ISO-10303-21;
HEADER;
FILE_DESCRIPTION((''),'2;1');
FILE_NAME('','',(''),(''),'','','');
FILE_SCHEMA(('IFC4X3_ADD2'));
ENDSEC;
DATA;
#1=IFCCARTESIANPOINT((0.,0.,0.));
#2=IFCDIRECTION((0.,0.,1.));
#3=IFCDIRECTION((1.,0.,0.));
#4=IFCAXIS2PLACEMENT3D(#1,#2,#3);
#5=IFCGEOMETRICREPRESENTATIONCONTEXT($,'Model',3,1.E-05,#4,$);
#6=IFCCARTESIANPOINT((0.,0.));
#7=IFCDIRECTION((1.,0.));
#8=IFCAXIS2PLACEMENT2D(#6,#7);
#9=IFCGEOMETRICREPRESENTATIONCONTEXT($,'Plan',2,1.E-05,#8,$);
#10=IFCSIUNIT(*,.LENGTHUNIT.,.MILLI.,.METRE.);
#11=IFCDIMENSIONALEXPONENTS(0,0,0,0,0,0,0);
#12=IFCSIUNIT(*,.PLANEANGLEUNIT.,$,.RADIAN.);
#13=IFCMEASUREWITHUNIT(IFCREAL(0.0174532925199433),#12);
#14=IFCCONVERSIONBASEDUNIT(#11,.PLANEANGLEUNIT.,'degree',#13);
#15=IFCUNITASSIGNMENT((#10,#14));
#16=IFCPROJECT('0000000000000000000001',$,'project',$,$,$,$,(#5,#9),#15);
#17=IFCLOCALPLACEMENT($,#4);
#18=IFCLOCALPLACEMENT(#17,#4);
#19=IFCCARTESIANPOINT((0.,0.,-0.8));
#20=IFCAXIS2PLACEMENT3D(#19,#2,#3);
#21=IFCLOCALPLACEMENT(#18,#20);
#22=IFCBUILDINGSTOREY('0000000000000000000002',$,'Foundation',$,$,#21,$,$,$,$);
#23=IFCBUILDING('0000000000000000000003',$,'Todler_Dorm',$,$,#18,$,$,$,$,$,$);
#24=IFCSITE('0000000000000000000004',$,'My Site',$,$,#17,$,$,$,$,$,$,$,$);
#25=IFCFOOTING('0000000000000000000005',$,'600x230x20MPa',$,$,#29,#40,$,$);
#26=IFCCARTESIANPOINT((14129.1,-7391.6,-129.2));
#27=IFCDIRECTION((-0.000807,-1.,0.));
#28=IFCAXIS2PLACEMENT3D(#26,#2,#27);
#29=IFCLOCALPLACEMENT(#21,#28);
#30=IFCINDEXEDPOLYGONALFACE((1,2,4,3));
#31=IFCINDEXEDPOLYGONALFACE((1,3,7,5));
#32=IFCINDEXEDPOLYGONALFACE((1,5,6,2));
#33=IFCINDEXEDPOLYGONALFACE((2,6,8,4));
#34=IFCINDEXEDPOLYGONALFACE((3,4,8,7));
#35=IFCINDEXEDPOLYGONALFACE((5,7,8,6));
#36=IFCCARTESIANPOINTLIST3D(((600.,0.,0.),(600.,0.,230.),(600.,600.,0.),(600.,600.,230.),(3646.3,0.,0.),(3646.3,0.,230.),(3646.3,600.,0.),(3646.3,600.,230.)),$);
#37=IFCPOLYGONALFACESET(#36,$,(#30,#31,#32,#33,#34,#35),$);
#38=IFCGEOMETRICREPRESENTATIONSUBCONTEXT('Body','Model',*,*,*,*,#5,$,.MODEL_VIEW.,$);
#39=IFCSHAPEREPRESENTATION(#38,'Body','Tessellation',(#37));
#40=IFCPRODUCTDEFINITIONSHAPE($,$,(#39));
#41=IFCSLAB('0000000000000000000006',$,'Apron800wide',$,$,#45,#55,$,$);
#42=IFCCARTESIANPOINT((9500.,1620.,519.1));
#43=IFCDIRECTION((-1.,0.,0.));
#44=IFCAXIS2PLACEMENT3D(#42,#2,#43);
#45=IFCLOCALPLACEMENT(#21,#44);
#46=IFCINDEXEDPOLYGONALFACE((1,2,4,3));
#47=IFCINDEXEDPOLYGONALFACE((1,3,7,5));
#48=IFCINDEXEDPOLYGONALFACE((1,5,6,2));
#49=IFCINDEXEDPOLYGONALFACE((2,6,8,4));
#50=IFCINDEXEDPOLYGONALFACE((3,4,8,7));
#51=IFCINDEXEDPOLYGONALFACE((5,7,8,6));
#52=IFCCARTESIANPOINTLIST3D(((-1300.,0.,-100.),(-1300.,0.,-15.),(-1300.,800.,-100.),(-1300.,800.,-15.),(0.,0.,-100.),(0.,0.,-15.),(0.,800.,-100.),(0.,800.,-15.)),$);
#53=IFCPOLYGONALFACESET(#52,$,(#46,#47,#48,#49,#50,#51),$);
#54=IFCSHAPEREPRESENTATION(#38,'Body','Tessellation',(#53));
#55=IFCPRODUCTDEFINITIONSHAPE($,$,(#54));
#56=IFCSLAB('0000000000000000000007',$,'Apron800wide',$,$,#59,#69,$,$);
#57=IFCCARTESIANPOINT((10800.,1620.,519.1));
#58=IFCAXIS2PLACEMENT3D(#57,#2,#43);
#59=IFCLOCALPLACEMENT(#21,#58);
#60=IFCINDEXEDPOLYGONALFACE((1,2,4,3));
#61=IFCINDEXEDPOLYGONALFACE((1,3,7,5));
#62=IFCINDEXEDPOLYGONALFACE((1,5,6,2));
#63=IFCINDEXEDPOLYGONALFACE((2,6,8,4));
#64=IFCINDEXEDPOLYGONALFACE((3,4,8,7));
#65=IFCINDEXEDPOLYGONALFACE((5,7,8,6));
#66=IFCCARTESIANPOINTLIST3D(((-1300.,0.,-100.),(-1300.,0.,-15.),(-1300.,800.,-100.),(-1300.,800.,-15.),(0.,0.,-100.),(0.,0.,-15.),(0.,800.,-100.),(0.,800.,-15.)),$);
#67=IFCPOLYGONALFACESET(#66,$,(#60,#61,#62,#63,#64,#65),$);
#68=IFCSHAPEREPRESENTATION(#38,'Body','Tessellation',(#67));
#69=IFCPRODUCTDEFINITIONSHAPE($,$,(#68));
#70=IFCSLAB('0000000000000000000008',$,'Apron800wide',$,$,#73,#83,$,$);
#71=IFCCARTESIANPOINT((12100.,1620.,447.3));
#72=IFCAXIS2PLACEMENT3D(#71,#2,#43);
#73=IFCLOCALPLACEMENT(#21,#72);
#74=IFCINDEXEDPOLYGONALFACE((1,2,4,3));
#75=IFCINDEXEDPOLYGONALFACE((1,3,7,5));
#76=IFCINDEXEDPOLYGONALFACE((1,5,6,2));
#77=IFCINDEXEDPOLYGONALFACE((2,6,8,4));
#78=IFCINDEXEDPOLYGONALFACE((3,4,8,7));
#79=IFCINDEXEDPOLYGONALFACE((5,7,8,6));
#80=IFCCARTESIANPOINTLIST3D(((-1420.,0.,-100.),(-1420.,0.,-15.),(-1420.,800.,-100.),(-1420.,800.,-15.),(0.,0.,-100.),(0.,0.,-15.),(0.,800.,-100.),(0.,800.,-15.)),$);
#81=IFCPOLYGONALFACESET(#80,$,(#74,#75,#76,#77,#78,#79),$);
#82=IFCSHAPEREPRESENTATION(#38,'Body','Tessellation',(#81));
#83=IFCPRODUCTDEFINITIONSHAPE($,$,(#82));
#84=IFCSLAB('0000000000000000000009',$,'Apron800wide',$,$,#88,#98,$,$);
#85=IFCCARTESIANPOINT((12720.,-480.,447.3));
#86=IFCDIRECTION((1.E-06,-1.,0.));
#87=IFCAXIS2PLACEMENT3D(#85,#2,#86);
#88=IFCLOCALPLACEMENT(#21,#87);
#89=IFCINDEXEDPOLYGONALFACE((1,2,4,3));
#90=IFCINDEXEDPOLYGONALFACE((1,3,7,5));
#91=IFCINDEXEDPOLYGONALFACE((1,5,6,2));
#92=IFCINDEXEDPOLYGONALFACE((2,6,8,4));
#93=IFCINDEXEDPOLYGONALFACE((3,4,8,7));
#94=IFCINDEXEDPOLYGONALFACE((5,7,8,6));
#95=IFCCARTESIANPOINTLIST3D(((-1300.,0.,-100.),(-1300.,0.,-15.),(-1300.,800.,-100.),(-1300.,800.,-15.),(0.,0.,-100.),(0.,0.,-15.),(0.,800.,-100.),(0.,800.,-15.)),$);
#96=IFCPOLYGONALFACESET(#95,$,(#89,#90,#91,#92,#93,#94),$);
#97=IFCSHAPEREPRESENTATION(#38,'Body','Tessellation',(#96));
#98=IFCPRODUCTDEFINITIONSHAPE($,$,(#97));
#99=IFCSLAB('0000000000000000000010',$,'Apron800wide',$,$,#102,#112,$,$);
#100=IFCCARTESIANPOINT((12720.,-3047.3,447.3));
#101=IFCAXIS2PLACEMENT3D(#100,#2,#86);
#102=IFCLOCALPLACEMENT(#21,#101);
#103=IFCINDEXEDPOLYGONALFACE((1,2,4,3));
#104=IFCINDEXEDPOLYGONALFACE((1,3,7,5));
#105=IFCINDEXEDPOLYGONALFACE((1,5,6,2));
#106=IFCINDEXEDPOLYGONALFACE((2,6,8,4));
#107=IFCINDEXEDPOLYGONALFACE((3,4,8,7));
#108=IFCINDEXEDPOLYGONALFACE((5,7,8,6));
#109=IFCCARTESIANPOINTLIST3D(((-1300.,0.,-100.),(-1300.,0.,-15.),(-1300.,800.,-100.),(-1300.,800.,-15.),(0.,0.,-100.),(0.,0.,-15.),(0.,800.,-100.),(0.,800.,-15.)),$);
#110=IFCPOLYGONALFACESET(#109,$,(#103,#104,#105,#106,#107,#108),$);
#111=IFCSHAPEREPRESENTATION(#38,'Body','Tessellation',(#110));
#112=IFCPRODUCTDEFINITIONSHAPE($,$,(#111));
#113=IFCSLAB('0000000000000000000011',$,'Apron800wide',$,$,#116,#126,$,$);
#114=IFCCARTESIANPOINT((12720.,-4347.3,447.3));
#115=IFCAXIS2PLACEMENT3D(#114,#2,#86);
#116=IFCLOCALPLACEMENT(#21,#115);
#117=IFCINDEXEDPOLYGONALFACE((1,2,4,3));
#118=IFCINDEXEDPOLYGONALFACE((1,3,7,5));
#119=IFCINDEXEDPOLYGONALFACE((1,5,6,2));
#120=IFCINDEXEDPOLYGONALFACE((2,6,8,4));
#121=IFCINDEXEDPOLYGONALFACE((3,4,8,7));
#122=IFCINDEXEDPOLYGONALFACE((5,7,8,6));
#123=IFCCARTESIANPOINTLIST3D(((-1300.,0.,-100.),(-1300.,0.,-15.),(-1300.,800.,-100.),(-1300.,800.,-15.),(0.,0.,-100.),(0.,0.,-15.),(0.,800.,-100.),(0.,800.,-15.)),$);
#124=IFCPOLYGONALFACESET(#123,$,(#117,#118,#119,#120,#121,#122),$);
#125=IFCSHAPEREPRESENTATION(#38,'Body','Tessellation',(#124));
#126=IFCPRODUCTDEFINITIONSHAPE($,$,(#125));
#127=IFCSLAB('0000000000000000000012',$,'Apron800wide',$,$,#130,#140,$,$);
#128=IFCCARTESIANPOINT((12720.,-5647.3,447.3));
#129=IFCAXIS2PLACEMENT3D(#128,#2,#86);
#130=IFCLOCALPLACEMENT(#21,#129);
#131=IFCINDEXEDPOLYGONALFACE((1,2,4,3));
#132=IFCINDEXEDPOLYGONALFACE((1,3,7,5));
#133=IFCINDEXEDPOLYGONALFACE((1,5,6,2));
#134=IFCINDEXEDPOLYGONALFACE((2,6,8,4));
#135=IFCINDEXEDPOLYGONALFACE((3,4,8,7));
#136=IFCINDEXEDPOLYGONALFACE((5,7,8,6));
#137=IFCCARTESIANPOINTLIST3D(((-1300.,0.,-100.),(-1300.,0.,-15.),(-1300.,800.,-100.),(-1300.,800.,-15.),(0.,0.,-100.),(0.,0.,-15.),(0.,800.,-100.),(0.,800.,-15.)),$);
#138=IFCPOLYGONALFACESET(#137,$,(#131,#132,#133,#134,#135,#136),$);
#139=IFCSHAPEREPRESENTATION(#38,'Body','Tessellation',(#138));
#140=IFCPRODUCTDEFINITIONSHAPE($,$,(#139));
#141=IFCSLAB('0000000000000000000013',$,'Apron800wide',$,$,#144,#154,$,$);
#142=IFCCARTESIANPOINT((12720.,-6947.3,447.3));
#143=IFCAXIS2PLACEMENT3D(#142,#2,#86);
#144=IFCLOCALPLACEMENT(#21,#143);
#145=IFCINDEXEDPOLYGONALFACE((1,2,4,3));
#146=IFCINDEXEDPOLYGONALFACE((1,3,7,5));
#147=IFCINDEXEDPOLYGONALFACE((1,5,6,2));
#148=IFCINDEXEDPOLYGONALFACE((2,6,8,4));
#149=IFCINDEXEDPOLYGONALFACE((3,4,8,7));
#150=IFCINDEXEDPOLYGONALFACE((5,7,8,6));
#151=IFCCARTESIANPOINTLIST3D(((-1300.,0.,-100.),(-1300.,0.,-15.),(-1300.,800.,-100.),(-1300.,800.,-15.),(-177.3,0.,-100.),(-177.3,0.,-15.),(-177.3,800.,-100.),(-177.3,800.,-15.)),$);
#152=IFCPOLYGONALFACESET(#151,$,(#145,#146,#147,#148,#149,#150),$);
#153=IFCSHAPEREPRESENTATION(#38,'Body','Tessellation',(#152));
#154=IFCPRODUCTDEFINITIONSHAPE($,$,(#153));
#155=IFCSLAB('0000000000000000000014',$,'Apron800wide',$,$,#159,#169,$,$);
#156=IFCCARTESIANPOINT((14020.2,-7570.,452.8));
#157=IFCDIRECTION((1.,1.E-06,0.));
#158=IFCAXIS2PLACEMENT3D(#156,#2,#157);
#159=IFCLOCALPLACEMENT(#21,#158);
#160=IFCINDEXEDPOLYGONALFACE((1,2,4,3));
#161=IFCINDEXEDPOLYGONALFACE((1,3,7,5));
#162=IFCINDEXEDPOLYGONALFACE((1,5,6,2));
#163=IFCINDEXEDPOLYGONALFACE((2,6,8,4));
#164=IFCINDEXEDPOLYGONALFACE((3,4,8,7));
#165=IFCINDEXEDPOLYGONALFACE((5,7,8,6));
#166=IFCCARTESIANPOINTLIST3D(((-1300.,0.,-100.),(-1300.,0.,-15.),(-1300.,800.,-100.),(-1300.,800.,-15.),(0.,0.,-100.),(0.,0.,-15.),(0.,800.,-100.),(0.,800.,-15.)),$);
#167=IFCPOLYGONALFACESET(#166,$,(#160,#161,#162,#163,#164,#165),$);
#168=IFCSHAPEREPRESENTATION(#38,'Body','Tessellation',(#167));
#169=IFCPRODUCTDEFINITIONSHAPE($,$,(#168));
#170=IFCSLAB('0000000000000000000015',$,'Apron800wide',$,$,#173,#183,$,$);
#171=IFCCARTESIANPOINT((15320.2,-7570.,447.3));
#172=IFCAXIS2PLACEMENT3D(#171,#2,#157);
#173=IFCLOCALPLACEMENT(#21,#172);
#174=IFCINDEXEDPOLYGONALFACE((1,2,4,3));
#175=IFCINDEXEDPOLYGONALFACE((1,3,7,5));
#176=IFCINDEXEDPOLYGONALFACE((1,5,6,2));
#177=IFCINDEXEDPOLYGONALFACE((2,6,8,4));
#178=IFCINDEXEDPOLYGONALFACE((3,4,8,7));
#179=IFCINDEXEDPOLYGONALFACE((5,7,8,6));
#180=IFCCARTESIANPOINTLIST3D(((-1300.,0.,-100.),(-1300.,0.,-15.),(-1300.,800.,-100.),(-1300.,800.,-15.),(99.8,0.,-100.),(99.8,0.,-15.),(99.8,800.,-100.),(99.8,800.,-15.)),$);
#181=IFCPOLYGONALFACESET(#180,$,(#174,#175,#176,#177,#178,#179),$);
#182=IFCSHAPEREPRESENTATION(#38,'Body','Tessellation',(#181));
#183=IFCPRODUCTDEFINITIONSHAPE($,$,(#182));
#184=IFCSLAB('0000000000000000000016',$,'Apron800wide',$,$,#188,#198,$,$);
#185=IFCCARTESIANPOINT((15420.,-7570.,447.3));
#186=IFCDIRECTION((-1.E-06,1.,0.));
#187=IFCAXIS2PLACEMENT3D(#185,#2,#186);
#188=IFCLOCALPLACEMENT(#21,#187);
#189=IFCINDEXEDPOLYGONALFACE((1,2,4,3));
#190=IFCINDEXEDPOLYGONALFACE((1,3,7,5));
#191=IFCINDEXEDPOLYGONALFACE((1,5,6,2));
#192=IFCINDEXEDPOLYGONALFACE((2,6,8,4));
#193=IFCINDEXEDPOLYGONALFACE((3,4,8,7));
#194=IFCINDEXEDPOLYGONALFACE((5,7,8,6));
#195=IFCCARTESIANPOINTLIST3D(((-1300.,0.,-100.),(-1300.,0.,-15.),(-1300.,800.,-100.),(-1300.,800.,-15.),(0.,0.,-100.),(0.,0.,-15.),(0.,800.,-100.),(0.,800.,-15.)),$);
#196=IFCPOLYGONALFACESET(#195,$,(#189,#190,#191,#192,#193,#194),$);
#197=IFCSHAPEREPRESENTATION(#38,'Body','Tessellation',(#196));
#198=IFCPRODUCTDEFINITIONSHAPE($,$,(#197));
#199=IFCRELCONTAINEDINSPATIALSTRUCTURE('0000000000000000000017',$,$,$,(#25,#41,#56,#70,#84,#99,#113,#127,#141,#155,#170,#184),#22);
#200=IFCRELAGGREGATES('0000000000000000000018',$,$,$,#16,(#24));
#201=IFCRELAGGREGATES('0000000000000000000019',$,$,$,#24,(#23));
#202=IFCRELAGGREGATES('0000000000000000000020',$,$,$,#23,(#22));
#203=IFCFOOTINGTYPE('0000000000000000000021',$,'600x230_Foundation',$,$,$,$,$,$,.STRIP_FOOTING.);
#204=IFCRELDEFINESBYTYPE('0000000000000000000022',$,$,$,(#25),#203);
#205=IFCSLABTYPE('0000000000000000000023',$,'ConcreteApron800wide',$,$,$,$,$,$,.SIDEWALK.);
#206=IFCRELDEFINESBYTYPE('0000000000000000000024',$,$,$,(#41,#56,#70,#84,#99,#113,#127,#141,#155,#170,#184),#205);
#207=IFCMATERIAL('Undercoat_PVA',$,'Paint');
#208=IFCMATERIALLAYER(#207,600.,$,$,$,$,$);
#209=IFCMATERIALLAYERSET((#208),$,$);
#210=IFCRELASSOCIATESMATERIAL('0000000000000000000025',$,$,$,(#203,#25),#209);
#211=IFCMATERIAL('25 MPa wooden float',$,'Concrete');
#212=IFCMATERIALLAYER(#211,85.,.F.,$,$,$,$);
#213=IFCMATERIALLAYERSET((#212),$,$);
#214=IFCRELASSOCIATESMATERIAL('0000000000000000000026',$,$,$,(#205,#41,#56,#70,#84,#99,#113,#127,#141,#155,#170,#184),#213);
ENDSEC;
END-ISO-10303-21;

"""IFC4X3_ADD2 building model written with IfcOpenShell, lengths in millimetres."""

from ifc_helpers import new_model, entity, si_unit, converted_unit, frame, origin_with_axes, origin_2d_with_axis, place, context, subcontext, project, spatial, line, indexed_curve, outline, extrude, material, layer, layer_set, layer_usage, type_object, element, save


model = new_model("IFC4X3_ADD2")

# Units and contexts
model_context = context("Model", 3, precision=1e-05, world=origin_with_axes())
plan_context = context("Plan", 2, precision=1e-05, world=origin_2d_with_axis())
body_context = subcontext(model_context, "Body", "Model", "MODEL_VIEW")
ifc_project = project(units=[si_unit("LENGTHUNIT", "METRE", prefix="MILLI"), converted_unit("PLANEANGLEUNIT", "degree", entity("IfcReal", 0.0174532925199433), si_unit("PLANEANGLEUNIT", "RADIAN"), dimensions=[0, 0, 0, 0, 0, 0, 0])], contexts=[model_context, plan_context])

# Site, building, storey
site_placement = place(None, origin_with_axes())
site = spatial("IfcSite", under=ifc_project, at=site_placement, Name="My Site")
building_placement = place(site_placement, origin_with_axes())
building = spatial("IfcBuilding", under=site, at=building_placement, Name="Todler_Dorm")
storey_placement = place(building_placement, frame((0.0, 0.0, -0.8), z_axis=(0.0, 0.0, 1.0), x_axis=(1.0, 0.0, 0.0)))
storey = spatial("IfcBuildingStorey", under=building, at=storey_placement, Name="Foundation")

# Footing
ifc_material_1 = material(Name="Undercoat_PVA", Category="Paint")
ifc_layer_1 = layer(ifc_material_1, 600.0)
ifc_layer_set_1 = layer_set([ifc_layer_1])
footing_type = type_object("IfcFootingType", Name="600x230_Foundation", PredefinedType="STRIP_FOOTING", material=ifc_layer_set_1)
ifc_layer_usage_1 = layer_usage(ifc_layer_set_1, "AXIS2", "POSITIVE", 0.0)
footing_1_placement = place(storey_placement, frame((14129.1, -7391.6, -129.2), z_axis=(0.0, 0.0, 1.0), x_axis=(-0.000807, -1.0, 0.0)))
element("IfcFooting", 1, at=footing_1_placement, inside=storey, type_object=footing_type, material=ifc_layer_usage_1, Name="600x230x20MPa", context=body_context, shape_type="SweptSolid", body=[
    extrude(outline(indexed_curve([(600.0, 0.0), (600.0, 600.0), (3646.3, 600.0), (3646.3, 0.0)], segments=[line(1, 2, 3, 4, 1)])), origin_with_axes(), (0.0, 0.0, 1.0), 230.0),
])

# Slabs
ifc_material_2 = material(Name="25 MPa wooden float", Category="Concrete")
ifc_layer_2 = layer(ifc_material_2, 85.0, ventilated=False)
ifc_layer_set_2 = layer_set([ifc_layer_2])
ifc_layer_usage_2 = layer_usage(ifc_layer_set_2, "AXIS3", "POSITIVE", -100.0)
slab_type = type_object("IfcSlabType", Name="ConcreteApron800wide", PredefinedType="SIDEWALK", material=ifc_layer_set_2)
slab_1_placement = place(storey_placement, frame((9500.0, 1620.0, 519.1), z_axis=(0.0, 0.0, 1.0), x_axis=(-1.0, 0.0, 0.0)))
element("IfcSlab", 2, at=slab_1_placement, inside=storey, type_object=slab_type, material=ifc_layer_usage_2, Name="Apron800wide", context=body_context, shape_type="SweptSolid", body=[
    extrude(outline(indexed_curve([(0.0, 0.0), (0.0, 800.0), (-1300.0, 800.0), (-1300.0, 0.0), (0.0, 0.0)])), frame((0.0, 0.0, -100.0), z_axis=(0.0, 0.0, 1.0), x_axis=(1.0, 0.0, 0.0)), (0.0, 0.0, 1.0), 85.0),
])
ifc_layer_usage_3 = layer_usage(ifc_layer_set_2, "AXIS3", "POSITIVE", -100.0)
slab_2_placement = place(storey_placement, frame((10800.0, 1620.0, 519.1), z_axis=(0.0, 0.0, 1.0), x_axis=(-1.0, 0.0, 0.0)))
element("IfcSlab", 3, at=slab_2_placement, inside=storey, type_object=slab_type, material=ifc_layer_usage_3, Name="Apron800wide", context=body_context, shape_type="SweptSolid", body=[
    extrude(outline(indexed_curve([(0.0, 0.0), (0.0, 800.0), (-1300.0, 800.0), (-1300.0, 0.0), (0.0, 0.0)])), frame((0.0, 0.0, -100.0), z_axis=(0.0, 0.0, 1.0), x_axis=(1.0, 0.0, 0.0)), (0.0, 0.0, 1.0), 85.0),
])
ifc_layer_usage_4 = layer_usage(ifc_layer_set_2, "AXIS3", "POSITIVE", -100.0)
slab_3_placement = place(storey_placement, frame((12100.0, 1620.0, 447.3), z_axis=(0.0, 0.0, 1.0), x_axis=(-1.0, 0.0, 0.0)))
element("IfcSlab", 4, at=slab_3_placement, inside=storey, type_object=slab_type, material=ifc_layer_usage_4, Name="Apron800wide", context=body_context, shape_type="SweptSolid", body=[
    extrude(outline(indexed_curve([(-1420.0, 0.0), (-1420.0, 800.0), (0.0, 800.0), (0.0, 0.0), (-1420.0, 0.0)])), frame((0.0, 0.0, -100.0), z_axis=(0.0, 0.0, 1.0), x_axis=(1.0, 0.0, 0.0)), (0.0, 0.0, 1.0), 85.0),
])
ifc_layer_usage_5 = layer_usage(ifc_layer_set_2, "AXIS3", "POSITIVE", -100.0)
slab_4_placement = place(storey_placement, frame((12720.0, -480.0, 447.3), z_axis=(0.0, 0.0, 1.0), x_axis=(0.000001, -1.0, 0.0)))
element("IfcSlab", 5, at=slab_4_placement, inside=storey, type_object=slab_type, material=ifc_layer_usage_5, Name="Apron800wide", context=body_context, shape_type="SweptSolid", body=[
    extrude(outline(indexed_curve([(0.0, 0.0), (0.0, 800.0), (-1300.0, 800.0), (-1300.0, 0.0), (0.0, 0.0)])), frame((0.0, 0.0, -100.0), z_axis=(0.0, 0.0, 1.0), x_axis=(1.0, 0.0, 0.0)), (0.0, 0.0, 1.0), 85.0),
])
ifc_layer_usage_6 = layer_usage(ifc_layer_set_2, "AXIS3", "POSITIVE", -100.0)
slab_5_placement = place(storey_placement, frame((12720.0, -3047.3, 447.3), z_axis=(0.0, 0.0, 1.0), x_axis=(0.000001, -1.0, 0.0)))
element("IfcSlab", 6, at=slab_5_placement, inside=storey, type_object=slab_type, material=ifc_layer_usage_6, Name="Apron800wide", context=body_context, shape_type="SweptSolid", body=[
    extrude(outline(indexed_curve([(0.0, 0.0), (0.0, 800.0), (-1300.0, 800.0), (-1300.0, 0.0), (0.0, 0.0)])), frame((0.0, 0.0, -100.0), z_axis=(0.0, 0.0, 1.0), x_axis=(1.0, 0.0, 0.0)), (0.0, 0.0, 1.0), 85.0),
])
ifc_layer_usage_7 = layer_usage(ifc_layer_set_2, "AXIS3", "POSITIVE", -100.0)
slab_6_placement = place(storey_placement, frame((12720.0, -4347.3, 447.3), z_axis=(0.0, 0.0, 1.0), x_axis=(0.000001, -1.0, 0.0)))
element("IfcSlab", 7, at=slab_6_placement, inside=storey, type_object=slab_type, material=ifc_layer_usage_7, Name="Apron800wide", context=body_context, shape_type="SweptSolid", body=[
    extrude(outline(indexed_curve([(0.0, 0.0), (0.0, 800.0), (-1300.0, 800.0), (-1300.0, 0.0), (0.0, 0.0)])), frame((0.0, 0.0, -100.0), z_axis=(0.0, 0.0, 1.0), x_axis=(1.0, 0.0, 0.0)), (0.0, 0.0, 1.0), 85.0),
])
ifc_layer_usage_8 = layer_usage(ifc_layer_set_2, "AXIS3", "POSITIVE", -100.0)
slab_7_placement = place(storey_placement, frame((12720.0, -5647.3, 447.3), z_axis=(0.0, 0.0, 1.0), x_axis=(0.000001, -1.0, 0.0)))
element("IfcSlab", 8, at=slab_7_placement, inside=storey, type_object=slab_type, material=ifc_layer_usage_8, Name="Apron800wide", context=body_context, shape_type="SweptSolid", body=[
    extrude(outline(indexed_curve([(0.0, 0.0), (0.0, 800.0), (-1300.0, 800.0), (-1300.0, 0.0), (0.0, 0.0)])), frame((0.0, 0.0, -100.0), z_axis=(0.0, 0.0, 1.0), x_axis=(1.0, 0.0, 0.0)), (0.0, 0.0, 1.0), 85.0),
])
ifc_layer_usage_9 = layer_usage(ifc_layer_set_2, "AXIS3", "POSITIVE", -100.0)
slab_8_placement = place(storey_placement, frame((12720.0, -6947.3, 447.3), z_axis=(0.0, 0.0, 1.0), x_axis=(0.000001, -1.0, 0.0)))
element("IfcSlab", 9, at=slab_8_placement, inside=storey, type_object=slab_type, material=ifc_layer_usage_9, Name="Apron800wide", context=body_context, shape_type="SweptSolid", body=[
    extrude(outline(indexed_curve([(-1300.0, 0.0), (-1300.0, 800.0), (-177.3, 800.0), (-177.3, 0.0), (-1300.0, 0.0)])), frame((0.0, 0.0, -100.0), z_axis=(0.0, 0.0, 1.0), x_axis=(1.0, 0.0, 0.0)), (0.0, 0.0, 1.0), 85.0),
])
ifc_layer_usage_10 = layer_usage(ifc_layer_set_2, "AXIS3", "POSITIVE", -100.0)
slab_9_placement = place(storey_placement, frame((14020.2, -7570.0, 452.8), z_axis=(0.0, 0.0, 1.0), x_axis=(1.0, 0.000001, 0.0)))
element("IfcSlab", 10, at=slab_9_placement, inside=storey, type_object=slab_type, material=ifc_layer_usage_10, Name="Apron800wide", context=body_context, shape_type="SweptSolid", body=[
    extrude(outline(indexed_curve([(0.0, 0.0), (0.0, 800.0), (-1300.0, 800.0), (-1300.0, 0.0), (0.0, 0.0)])), frame((0.0, 0.0, -100.0), z_axis=(0.0, 0.0, 1.0), x_axis=(1.0, 0.0, 0.0)), (0.0, 0.0, 1.0), 85.0),
])
ifc_layer_usage_11 = layer_usage(ifc_layer_set_2, "AXIS3", "POSITIVE", -100.0)
slab_10_placement = place(storey_placement, frame((15320.2, -7570.0, 447.3), z_axis=(0.0, 0.0, 1.0), x_axis=(1.0, 0.000001, 0.0)))
element("IfcSlab", 11, at=slab_10_placement, inside=storey, type_object=slab_type, material=ifc_layer_usage_11, Name="Apron800wide", context=body_context, shape_type="SweptSolid", body=[
    extrude(outline(indexed_curve([(-1300.0, 0.0), (-1300.0, 800.0), (99.8, 800.0), (99.8, 0.0), (-1300.0, 0.0)])), frame((0.0, 0.0, -100.0), z_axis=(0.0, 0.0, 1.0), x_axis=(1.0, 0.0, 0.0)), (0.0, 0.0, 1.0), 85.0),
])
ifc_layer_usage_12 = layer_usage(ifc_layer_set_2, "AXIS3", "POSITIVE", -100.0)
slab_11_placement = place(storey_placement, frame((15420.0, -7570.0, 447.3), z_axis=(0.0, 0.0, 1.0), x_axis=(-0.000001, 1.0, 0.0)))
element("IfcSlab", 12, at=slab_11_placement, inside=storey, type_object=slab_type, material=ifc_layer_usage_12, Name="Apron800wide", context=body_context, shape_type="SweptSolid", body=[
    extrude(outline(indexed_curve([(0.0, 0.0), (0.0, 800.0), (-1300.0, 800.0), (-1300.0, 0.0), (0.0, 0.0)])), frame((0.0, 0.0, -100.0), z_axis=(0.0, 0.0, 1.0), x_axis=(1.0, 0.0, 0.0)), (0.0, 0.0, 1.0), 85.0),
])

save(model, "model.ifc")
